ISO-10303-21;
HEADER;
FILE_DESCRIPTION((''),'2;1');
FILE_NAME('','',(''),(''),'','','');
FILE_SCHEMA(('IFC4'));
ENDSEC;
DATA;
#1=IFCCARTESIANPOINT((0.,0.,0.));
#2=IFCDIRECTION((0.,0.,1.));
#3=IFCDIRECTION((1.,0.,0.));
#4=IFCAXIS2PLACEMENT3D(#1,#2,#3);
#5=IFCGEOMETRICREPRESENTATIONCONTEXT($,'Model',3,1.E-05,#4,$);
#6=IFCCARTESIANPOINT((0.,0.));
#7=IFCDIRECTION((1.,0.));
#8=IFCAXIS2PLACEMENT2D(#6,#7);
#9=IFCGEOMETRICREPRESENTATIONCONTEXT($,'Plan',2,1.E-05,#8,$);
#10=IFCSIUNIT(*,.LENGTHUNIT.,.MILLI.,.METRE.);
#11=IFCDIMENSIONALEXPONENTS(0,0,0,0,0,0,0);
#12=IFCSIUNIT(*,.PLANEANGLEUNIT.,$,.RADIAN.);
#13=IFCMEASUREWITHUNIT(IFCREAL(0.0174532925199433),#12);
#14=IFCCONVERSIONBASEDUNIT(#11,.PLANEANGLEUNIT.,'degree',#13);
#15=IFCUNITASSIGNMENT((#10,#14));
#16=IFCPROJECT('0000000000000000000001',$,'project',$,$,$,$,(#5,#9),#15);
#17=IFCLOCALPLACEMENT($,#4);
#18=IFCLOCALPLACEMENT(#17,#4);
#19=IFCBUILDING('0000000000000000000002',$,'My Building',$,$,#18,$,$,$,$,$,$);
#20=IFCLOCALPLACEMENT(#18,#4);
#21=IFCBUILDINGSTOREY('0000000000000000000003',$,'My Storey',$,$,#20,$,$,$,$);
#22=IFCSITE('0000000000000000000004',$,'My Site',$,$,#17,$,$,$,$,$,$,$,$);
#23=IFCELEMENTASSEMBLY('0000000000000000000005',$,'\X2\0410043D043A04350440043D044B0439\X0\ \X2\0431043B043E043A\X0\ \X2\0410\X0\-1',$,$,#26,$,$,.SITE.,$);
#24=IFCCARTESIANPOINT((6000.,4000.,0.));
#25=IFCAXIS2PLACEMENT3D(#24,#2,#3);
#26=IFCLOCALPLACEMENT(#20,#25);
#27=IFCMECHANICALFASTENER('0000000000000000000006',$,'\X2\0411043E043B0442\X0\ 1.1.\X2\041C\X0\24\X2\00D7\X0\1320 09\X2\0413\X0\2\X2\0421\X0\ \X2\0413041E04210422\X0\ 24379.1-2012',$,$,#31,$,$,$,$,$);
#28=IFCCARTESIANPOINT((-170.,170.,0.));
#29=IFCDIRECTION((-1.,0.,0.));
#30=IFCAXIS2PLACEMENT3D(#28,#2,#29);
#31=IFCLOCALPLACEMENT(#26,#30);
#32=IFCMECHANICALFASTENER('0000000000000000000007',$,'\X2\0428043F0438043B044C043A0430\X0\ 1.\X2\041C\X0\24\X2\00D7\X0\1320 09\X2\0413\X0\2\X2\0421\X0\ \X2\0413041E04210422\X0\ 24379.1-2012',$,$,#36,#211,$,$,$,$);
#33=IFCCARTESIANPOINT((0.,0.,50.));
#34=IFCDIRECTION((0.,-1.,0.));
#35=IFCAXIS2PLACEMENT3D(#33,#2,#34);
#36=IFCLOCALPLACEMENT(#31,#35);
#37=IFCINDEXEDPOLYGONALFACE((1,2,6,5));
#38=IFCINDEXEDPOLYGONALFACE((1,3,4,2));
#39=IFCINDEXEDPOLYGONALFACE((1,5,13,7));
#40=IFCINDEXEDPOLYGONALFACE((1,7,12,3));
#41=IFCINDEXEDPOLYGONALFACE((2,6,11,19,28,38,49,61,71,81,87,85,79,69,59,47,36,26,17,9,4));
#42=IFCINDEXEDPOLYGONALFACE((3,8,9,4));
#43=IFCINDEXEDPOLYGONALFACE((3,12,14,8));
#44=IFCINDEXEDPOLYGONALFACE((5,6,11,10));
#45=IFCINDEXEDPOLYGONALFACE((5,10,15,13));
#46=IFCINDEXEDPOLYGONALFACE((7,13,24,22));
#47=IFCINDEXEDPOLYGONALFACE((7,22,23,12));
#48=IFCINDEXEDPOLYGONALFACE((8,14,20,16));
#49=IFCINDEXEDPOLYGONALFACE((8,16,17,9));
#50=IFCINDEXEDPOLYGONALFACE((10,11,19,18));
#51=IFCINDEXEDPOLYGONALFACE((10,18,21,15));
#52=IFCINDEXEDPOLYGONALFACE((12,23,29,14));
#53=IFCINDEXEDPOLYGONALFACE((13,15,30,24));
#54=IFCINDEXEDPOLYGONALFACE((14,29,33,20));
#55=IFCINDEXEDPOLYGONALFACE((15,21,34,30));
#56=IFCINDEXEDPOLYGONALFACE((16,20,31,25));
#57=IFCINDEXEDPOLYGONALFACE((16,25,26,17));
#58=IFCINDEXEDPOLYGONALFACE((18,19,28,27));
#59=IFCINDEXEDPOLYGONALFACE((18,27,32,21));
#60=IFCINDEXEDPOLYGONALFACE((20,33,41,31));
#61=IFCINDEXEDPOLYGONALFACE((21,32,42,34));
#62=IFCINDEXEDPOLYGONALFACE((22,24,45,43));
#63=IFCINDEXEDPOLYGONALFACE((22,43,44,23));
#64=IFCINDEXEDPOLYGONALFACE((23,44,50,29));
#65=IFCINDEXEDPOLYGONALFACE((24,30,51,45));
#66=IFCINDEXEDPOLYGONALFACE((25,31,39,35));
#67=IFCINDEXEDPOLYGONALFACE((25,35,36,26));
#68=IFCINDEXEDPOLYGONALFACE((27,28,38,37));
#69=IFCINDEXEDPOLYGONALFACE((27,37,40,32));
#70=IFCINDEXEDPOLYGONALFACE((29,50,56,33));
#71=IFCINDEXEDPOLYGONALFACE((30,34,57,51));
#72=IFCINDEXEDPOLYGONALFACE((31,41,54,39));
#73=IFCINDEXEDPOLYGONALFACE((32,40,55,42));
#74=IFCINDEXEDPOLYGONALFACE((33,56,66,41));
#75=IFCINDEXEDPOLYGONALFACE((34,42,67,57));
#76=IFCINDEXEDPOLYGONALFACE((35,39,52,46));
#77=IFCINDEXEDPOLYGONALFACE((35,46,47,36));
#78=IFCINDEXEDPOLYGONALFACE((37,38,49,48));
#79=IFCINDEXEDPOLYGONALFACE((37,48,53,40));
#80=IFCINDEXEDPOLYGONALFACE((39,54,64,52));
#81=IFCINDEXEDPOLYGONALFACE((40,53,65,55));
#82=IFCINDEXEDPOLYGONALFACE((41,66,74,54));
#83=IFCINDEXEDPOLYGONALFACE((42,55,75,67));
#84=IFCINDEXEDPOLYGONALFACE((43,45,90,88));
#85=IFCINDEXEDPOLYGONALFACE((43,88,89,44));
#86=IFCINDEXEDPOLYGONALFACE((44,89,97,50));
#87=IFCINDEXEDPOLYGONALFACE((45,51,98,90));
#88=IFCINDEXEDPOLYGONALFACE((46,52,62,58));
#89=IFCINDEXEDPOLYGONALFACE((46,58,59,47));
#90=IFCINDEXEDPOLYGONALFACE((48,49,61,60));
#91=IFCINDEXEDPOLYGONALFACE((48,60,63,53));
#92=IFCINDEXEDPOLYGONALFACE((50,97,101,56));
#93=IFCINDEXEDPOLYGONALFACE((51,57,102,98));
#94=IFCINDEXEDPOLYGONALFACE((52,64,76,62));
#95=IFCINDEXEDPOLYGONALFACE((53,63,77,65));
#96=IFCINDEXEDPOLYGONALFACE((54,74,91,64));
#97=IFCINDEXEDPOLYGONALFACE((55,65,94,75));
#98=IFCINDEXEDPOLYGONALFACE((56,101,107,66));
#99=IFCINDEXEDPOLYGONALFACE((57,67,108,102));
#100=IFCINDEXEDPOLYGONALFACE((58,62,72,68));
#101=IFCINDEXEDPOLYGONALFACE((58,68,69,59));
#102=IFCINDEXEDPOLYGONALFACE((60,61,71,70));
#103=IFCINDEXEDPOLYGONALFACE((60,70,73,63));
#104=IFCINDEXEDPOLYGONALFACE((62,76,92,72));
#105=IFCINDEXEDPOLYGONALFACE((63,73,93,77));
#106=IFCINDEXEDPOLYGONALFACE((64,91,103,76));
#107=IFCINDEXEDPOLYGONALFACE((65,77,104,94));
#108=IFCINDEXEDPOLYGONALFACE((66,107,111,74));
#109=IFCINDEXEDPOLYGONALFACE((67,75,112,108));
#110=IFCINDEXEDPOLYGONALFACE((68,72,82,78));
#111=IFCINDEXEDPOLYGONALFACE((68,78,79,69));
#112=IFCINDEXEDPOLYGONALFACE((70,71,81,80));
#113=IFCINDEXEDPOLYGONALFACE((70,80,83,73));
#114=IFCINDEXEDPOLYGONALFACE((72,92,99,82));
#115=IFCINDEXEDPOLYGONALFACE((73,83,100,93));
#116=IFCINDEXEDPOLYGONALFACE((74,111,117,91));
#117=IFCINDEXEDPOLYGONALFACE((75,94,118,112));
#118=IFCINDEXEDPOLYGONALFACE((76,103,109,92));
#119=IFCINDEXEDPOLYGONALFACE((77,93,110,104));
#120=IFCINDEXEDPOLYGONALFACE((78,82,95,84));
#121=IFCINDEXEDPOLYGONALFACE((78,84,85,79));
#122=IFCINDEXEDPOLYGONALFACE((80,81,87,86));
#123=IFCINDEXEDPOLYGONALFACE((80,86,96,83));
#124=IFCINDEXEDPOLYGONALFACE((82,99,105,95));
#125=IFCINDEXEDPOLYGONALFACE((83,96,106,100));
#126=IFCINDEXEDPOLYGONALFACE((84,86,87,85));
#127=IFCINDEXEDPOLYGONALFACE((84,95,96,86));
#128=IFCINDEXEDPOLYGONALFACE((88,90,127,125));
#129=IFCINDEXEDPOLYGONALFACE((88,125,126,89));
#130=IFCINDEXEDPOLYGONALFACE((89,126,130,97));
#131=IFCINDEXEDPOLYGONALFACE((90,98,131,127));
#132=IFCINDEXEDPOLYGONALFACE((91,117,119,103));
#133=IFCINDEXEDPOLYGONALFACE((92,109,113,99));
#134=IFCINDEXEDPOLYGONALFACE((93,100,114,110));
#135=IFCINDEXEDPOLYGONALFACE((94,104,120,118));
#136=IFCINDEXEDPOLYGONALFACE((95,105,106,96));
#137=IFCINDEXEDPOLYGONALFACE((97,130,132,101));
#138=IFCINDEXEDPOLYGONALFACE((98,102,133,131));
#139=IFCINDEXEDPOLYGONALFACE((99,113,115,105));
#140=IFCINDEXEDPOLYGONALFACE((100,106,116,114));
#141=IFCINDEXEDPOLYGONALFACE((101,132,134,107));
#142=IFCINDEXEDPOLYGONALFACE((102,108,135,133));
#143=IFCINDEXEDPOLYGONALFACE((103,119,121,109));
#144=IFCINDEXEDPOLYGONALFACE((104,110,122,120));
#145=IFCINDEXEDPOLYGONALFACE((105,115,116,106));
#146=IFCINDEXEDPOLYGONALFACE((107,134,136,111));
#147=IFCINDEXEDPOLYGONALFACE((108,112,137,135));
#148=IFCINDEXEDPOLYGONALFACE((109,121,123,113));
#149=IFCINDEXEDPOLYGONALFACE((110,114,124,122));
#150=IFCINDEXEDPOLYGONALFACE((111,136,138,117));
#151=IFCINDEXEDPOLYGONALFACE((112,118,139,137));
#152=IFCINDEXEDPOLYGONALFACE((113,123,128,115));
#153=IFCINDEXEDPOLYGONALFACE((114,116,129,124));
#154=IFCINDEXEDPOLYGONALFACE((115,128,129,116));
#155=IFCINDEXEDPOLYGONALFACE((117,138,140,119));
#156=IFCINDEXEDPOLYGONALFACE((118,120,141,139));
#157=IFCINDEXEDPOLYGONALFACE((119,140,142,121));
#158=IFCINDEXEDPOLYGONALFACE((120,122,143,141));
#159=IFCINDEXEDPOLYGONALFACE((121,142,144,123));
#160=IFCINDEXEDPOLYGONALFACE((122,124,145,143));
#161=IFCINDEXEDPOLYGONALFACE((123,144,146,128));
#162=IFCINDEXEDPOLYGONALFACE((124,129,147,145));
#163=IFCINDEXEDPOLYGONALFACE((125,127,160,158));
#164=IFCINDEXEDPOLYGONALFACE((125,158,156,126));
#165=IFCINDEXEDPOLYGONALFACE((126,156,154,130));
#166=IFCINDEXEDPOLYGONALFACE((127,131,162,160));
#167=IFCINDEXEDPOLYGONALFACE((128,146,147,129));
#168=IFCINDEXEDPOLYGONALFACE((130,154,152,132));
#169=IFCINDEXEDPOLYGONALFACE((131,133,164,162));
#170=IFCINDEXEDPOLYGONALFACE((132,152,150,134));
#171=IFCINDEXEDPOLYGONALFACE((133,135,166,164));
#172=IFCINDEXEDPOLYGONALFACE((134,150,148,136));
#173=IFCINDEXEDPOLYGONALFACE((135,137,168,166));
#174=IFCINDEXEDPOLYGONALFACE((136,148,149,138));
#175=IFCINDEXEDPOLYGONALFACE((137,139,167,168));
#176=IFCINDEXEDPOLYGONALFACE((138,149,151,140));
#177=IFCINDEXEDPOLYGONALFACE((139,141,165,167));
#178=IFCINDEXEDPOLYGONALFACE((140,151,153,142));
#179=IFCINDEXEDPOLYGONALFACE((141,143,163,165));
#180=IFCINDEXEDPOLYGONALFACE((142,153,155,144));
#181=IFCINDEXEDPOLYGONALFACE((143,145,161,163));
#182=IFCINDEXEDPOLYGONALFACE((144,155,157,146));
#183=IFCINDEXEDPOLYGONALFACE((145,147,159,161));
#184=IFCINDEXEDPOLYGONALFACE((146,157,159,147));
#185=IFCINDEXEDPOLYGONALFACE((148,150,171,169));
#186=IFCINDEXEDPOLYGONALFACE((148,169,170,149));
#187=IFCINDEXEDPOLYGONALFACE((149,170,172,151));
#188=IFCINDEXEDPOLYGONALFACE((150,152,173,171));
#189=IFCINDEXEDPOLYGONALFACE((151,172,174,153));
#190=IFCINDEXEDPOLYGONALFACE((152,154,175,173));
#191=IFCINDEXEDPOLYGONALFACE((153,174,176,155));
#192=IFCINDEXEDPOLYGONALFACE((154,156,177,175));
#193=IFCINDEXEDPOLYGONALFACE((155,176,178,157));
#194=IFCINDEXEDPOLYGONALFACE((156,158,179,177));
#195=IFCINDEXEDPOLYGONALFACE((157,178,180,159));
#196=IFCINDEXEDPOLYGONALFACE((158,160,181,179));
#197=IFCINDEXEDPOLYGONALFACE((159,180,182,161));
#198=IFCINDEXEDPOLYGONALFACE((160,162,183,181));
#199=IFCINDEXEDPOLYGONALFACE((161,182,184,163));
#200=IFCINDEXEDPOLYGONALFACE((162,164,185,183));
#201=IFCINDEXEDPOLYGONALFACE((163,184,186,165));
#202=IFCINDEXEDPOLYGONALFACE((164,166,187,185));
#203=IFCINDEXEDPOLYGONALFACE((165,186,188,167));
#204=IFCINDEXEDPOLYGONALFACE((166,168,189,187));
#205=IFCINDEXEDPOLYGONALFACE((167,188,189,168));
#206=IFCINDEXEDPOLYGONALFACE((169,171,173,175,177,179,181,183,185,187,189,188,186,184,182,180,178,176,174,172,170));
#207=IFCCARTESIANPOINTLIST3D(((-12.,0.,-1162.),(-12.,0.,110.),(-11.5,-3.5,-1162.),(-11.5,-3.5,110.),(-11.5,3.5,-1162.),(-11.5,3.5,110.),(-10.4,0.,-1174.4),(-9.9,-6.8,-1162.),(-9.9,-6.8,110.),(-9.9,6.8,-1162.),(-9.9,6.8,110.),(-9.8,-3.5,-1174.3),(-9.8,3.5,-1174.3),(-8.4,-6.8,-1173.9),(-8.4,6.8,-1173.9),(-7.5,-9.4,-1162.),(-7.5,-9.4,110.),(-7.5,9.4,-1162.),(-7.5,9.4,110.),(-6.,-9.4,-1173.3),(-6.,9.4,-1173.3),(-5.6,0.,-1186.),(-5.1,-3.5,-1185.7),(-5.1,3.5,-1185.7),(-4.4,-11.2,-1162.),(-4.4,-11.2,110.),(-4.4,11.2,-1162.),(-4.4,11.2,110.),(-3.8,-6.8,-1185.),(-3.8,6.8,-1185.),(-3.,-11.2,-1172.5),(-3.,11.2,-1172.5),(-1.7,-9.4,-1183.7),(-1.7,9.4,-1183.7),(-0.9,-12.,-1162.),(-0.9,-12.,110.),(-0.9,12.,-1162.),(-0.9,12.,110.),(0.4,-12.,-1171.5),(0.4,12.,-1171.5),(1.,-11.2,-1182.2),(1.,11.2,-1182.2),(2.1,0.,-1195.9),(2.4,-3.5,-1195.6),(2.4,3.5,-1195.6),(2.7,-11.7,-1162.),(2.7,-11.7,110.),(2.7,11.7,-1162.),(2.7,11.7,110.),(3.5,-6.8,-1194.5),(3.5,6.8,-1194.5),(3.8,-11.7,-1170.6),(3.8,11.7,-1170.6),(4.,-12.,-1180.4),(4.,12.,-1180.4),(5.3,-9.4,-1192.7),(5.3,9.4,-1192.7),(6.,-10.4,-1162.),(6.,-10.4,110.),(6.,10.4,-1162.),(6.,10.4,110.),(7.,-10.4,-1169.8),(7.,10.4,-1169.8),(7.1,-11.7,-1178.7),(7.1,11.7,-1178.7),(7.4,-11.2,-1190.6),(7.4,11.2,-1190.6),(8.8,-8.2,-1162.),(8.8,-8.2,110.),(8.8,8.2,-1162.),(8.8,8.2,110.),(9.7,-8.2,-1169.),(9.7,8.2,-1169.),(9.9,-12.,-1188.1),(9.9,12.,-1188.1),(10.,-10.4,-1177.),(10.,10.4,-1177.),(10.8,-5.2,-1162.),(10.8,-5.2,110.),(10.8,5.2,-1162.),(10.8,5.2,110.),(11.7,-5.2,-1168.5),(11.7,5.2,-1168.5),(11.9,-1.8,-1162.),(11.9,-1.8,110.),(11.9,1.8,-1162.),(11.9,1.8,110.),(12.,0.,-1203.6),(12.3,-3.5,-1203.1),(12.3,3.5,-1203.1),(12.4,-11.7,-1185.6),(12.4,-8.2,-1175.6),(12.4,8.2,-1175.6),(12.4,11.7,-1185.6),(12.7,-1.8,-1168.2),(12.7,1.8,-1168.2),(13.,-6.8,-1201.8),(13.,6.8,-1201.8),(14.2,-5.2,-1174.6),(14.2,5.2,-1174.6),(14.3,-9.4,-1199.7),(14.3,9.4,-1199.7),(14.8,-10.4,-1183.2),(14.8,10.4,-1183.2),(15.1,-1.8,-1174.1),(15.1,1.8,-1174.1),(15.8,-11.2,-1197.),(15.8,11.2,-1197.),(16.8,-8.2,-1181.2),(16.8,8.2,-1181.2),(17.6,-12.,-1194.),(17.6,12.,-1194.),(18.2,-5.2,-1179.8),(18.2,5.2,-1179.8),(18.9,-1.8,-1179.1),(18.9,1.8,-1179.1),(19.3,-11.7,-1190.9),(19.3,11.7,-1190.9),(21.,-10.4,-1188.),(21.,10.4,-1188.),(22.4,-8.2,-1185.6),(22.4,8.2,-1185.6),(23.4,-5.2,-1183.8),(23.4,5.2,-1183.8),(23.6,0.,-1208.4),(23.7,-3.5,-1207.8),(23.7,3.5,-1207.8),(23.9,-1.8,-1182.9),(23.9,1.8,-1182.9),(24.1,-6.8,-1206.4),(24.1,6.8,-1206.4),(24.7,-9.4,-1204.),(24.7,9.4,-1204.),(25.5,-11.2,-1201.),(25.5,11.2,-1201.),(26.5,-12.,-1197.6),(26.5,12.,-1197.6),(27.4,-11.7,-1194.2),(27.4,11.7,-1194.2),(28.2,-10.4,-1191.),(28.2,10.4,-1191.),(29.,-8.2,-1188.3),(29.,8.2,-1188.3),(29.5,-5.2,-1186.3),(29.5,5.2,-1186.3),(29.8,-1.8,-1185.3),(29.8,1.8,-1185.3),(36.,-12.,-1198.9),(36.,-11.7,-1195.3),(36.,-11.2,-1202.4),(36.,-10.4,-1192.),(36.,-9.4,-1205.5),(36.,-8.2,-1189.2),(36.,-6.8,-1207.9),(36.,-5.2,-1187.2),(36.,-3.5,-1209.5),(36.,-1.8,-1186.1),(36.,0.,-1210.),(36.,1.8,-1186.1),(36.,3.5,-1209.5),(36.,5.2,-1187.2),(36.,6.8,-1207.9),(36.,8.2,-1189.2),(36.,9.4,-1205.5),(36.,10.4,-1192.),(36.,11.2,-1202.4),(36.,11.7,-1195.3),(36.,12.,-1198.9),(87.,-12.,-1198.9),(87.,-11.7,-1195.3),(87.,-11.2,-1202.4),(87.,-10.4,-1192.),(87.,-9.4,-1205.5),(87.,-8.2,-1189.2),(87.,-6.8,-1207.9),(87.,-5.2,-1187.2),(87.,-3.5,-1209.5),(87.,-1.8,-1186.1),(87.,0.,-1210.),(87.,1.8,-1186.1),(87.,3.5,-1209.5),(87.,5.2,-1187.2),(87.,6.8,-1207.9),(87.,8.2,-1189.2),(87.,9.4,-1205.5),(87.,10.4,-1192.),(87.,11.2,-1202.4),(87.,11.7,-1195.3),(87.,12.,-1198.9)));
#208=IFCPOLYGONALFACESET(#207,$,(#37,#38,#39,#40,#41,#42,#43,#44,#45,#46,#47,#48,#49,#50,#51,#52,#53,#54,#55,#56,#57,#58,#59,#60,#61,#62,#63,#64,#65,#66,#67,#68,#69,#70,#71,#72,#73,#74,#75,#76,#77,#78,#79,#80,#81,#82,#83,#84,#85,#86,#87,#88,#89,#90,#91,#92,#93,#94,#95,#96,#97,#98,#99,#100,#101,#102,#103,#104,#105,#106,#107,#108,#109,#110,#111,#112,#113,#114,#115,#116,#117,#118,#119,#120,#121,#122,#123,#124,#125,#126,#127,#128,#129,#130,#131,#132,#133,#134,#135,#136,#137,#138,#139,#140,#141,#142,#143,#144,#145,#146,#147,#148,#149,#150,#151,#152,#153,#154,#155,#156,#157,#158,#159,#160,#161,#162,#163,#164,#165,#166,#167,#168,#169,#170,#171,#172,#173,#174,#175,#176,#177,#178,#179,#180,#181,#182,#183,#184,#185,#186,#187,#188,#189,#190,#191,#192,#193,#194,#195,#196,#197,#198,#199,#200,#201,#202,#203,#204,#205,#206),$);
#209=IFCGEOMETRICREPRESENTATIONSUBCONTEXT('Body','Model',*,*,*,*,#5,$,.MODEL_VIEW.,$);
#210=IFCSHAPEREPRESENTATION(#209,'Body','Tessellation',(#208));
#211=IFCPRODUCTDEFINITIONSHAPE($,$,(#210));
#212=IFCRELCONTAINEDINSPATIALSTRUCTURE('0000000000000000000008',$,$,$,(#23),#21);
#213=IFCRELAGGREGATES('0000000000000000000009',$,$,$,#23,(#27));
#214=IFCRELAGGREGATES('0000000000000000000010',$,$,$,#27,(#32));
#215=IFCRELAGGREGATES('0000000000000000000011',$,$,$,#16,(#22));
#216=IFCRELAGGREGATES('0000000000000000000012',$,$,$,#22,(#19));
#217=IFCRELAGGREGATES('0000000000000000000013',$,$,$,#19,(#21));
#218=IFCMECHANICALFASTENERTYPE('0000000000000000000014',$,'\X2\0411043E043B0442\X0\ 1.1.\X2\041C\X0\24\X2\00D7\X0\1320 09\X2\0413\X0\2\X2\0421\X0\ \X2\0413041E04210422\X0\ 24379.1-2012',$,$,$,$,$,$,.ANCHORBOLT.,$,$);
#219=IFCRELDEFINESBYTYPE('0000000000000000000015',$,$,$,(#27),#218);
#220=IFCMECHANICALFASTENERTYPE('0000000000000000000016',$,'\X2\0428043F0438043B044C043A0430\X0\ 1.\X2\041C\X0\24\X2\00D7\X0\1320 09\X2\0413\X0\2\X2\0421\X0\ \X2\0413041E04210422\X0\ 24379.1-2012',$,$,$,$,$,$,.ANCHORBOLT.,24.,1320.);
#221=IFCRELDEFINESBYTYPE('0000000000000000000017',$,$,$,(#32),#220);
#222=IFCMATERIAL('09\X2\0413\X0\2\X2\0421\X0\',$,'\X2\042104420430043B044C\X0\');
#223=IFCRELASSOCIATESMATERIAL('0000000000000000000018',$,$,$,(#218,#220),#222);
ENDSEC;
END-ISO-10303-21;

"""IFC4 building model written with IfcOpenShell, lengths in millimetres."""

from ifc_helpers import new_model, entity, si_unit, converted_unit, frame, origin_with_axes, origin_2d_with_axis, place, context, subcontext, project, spatial, source, transform, mapped, material, type_object, type_shapes, element, aggregate, save


model = new_model("IFC4")

# Units and contexts
model_context = context("Model", 3, precision=1e-05, world=origin_with_axes())
plan_context = context("Plan", 2, precision=1e-05, world=origin_2d_with_axis())
body_context = subcontext(model_context, "Body", "Model", "MODEL_VIEW")
ifc_project = project(units=[si_unit("LENGTHUNIT", "METRE", prefix="MILLI"), converted_unit("PLANEANGLEUNIT", "degree", entity("IfcReal", 0.0174532925199433), si_unit("PLANEANGLEUNIT", "RADIAN"), dimensions=[0, 0, 0, 0, 0, 0, 0])], contexts=[model_context, plan_context])

# Site, building, storey
site_placement = place(None, origin_with_axes())
site = spatial("IfcSite", under=ifc_project, at=site_placement, Name="My Site")
building_placement = place(site_placement, origin_with_axes())
building = spatial("IfcBuilding", under=site, at=building_placement, Name="My Building")
storey_placement = place(building_placement, origin_with_axes())
storey = spatial("IfcBuildingStorey", under=building, at=storey_placement, Name="My Storey")

# Element assembly, mechanical fasteners
ifc_material_1 = material(Name="09Г2С", Category="Сталь")
mechanical_fastener_type_1 = type_object("IfcMechanicalFastenerType", Name="Болт 1.1.М24×1320 09Г2С ГОСТ 24379.1-2012", PredefinedType="ANCHORBOLT", material=ifc_material_1)
mechanical_fastener_type_2 = type_object("IfcMechanicalFastenerType", Name="Шпилька 1.М24×1320 09Г2С ГОСТ 24379.1-2012", NominalDiameter=24.0, NominalLength=1320.0, PredefinedType="ANCHORBOLT", material=ifc_material_1)
shared_shape_1 = source(frame((0.0, 0.0, 110.0), z_axis=(0.0, 0.0, 1.0), x_axis=(1.0, 0.0, 0.0)), body_context, "Body", "AdvancedSweptSolid", [
    entity("IfcSweptDiskSolid", entity("IfcIndexedPolyCurve", entity("IfcCartesianPointList3D", [[0.0, 0.0, 0.0], [0.0, 0.0, -1272.0], [10.5, 0.0, -1297.5], [36.0, 0.0, -1308.0], [87.0, 0.0, -1308.0]]), [entity("IfcLineIndex", [1, 2]), entity("IfcArcIndex", [2, 3, 4]), entity("IfcLineIndex", [4, 5])]), 12.0),
])
type_shapes(mechanical_fastener_type_2, [shared_shape_1])
assembly_1_placement = place(storey_placement, frame((6000.0, 4000.0, 0.0), z_axis=(0.0, 0.0, 1.0), x_axis=(1.0, 0.0, 0.0)))
assembly_1 = element("IfcElementAssembly", 1, at=assembly_1_placement, inside=storey, Name="Анкерный блок А-1", AssemblyPlace="SITE")
mechanical_fastener_1_placement = place(assembly_1_placement, frame((-170.0, 170.0, 0.0), z_axis=(0.0, 0.0, 1.0), x_axis=(-1.0, 0.0, 0.0)))
mechanical_fastener_1 = element("IfcMechanicalFastener", 2, at=mechanical_fastener_1_placement, type_object=mechanical_fastener_type_1, Name="Болт 1.1.М24×1320 09Г2С ГОСТ 24379.1-2012")
aggregate(assembly_1, [mechanical_fastener_1])
mechanical_fastener_2_placement = place(mechanical_fastener_1_placement, frame((0.0, 0.0, 50.0), z_axis=(0.0, 0.0, 1.0), x_axis=(0.0, -1.0, 0.0)))
mechanical_fastener_2 = element("IfcMechanicalFastener", 3, at=mechanical_fastener_2_placement, type_object=mechanical_fastener_type_2, Name="Шпилька 1.М24×1320 09Г2С ГОСТ 24379.1-2012", context=body_context, shape_type="MappedRepresentation", body=[
    mapped(shared_shape_1, transform((0.0, 0.0, 0.0), x_axis=(1.0, 0.0, 0.0), y_axis=(0.0, 1.0, 0.0), z_axis=(0.0, 0.0, 1.0), scale=1.0)),
])

aggregate(mechanical_fastener_1, [mechanical_fastener_2])

save(model, "model.ifc")
